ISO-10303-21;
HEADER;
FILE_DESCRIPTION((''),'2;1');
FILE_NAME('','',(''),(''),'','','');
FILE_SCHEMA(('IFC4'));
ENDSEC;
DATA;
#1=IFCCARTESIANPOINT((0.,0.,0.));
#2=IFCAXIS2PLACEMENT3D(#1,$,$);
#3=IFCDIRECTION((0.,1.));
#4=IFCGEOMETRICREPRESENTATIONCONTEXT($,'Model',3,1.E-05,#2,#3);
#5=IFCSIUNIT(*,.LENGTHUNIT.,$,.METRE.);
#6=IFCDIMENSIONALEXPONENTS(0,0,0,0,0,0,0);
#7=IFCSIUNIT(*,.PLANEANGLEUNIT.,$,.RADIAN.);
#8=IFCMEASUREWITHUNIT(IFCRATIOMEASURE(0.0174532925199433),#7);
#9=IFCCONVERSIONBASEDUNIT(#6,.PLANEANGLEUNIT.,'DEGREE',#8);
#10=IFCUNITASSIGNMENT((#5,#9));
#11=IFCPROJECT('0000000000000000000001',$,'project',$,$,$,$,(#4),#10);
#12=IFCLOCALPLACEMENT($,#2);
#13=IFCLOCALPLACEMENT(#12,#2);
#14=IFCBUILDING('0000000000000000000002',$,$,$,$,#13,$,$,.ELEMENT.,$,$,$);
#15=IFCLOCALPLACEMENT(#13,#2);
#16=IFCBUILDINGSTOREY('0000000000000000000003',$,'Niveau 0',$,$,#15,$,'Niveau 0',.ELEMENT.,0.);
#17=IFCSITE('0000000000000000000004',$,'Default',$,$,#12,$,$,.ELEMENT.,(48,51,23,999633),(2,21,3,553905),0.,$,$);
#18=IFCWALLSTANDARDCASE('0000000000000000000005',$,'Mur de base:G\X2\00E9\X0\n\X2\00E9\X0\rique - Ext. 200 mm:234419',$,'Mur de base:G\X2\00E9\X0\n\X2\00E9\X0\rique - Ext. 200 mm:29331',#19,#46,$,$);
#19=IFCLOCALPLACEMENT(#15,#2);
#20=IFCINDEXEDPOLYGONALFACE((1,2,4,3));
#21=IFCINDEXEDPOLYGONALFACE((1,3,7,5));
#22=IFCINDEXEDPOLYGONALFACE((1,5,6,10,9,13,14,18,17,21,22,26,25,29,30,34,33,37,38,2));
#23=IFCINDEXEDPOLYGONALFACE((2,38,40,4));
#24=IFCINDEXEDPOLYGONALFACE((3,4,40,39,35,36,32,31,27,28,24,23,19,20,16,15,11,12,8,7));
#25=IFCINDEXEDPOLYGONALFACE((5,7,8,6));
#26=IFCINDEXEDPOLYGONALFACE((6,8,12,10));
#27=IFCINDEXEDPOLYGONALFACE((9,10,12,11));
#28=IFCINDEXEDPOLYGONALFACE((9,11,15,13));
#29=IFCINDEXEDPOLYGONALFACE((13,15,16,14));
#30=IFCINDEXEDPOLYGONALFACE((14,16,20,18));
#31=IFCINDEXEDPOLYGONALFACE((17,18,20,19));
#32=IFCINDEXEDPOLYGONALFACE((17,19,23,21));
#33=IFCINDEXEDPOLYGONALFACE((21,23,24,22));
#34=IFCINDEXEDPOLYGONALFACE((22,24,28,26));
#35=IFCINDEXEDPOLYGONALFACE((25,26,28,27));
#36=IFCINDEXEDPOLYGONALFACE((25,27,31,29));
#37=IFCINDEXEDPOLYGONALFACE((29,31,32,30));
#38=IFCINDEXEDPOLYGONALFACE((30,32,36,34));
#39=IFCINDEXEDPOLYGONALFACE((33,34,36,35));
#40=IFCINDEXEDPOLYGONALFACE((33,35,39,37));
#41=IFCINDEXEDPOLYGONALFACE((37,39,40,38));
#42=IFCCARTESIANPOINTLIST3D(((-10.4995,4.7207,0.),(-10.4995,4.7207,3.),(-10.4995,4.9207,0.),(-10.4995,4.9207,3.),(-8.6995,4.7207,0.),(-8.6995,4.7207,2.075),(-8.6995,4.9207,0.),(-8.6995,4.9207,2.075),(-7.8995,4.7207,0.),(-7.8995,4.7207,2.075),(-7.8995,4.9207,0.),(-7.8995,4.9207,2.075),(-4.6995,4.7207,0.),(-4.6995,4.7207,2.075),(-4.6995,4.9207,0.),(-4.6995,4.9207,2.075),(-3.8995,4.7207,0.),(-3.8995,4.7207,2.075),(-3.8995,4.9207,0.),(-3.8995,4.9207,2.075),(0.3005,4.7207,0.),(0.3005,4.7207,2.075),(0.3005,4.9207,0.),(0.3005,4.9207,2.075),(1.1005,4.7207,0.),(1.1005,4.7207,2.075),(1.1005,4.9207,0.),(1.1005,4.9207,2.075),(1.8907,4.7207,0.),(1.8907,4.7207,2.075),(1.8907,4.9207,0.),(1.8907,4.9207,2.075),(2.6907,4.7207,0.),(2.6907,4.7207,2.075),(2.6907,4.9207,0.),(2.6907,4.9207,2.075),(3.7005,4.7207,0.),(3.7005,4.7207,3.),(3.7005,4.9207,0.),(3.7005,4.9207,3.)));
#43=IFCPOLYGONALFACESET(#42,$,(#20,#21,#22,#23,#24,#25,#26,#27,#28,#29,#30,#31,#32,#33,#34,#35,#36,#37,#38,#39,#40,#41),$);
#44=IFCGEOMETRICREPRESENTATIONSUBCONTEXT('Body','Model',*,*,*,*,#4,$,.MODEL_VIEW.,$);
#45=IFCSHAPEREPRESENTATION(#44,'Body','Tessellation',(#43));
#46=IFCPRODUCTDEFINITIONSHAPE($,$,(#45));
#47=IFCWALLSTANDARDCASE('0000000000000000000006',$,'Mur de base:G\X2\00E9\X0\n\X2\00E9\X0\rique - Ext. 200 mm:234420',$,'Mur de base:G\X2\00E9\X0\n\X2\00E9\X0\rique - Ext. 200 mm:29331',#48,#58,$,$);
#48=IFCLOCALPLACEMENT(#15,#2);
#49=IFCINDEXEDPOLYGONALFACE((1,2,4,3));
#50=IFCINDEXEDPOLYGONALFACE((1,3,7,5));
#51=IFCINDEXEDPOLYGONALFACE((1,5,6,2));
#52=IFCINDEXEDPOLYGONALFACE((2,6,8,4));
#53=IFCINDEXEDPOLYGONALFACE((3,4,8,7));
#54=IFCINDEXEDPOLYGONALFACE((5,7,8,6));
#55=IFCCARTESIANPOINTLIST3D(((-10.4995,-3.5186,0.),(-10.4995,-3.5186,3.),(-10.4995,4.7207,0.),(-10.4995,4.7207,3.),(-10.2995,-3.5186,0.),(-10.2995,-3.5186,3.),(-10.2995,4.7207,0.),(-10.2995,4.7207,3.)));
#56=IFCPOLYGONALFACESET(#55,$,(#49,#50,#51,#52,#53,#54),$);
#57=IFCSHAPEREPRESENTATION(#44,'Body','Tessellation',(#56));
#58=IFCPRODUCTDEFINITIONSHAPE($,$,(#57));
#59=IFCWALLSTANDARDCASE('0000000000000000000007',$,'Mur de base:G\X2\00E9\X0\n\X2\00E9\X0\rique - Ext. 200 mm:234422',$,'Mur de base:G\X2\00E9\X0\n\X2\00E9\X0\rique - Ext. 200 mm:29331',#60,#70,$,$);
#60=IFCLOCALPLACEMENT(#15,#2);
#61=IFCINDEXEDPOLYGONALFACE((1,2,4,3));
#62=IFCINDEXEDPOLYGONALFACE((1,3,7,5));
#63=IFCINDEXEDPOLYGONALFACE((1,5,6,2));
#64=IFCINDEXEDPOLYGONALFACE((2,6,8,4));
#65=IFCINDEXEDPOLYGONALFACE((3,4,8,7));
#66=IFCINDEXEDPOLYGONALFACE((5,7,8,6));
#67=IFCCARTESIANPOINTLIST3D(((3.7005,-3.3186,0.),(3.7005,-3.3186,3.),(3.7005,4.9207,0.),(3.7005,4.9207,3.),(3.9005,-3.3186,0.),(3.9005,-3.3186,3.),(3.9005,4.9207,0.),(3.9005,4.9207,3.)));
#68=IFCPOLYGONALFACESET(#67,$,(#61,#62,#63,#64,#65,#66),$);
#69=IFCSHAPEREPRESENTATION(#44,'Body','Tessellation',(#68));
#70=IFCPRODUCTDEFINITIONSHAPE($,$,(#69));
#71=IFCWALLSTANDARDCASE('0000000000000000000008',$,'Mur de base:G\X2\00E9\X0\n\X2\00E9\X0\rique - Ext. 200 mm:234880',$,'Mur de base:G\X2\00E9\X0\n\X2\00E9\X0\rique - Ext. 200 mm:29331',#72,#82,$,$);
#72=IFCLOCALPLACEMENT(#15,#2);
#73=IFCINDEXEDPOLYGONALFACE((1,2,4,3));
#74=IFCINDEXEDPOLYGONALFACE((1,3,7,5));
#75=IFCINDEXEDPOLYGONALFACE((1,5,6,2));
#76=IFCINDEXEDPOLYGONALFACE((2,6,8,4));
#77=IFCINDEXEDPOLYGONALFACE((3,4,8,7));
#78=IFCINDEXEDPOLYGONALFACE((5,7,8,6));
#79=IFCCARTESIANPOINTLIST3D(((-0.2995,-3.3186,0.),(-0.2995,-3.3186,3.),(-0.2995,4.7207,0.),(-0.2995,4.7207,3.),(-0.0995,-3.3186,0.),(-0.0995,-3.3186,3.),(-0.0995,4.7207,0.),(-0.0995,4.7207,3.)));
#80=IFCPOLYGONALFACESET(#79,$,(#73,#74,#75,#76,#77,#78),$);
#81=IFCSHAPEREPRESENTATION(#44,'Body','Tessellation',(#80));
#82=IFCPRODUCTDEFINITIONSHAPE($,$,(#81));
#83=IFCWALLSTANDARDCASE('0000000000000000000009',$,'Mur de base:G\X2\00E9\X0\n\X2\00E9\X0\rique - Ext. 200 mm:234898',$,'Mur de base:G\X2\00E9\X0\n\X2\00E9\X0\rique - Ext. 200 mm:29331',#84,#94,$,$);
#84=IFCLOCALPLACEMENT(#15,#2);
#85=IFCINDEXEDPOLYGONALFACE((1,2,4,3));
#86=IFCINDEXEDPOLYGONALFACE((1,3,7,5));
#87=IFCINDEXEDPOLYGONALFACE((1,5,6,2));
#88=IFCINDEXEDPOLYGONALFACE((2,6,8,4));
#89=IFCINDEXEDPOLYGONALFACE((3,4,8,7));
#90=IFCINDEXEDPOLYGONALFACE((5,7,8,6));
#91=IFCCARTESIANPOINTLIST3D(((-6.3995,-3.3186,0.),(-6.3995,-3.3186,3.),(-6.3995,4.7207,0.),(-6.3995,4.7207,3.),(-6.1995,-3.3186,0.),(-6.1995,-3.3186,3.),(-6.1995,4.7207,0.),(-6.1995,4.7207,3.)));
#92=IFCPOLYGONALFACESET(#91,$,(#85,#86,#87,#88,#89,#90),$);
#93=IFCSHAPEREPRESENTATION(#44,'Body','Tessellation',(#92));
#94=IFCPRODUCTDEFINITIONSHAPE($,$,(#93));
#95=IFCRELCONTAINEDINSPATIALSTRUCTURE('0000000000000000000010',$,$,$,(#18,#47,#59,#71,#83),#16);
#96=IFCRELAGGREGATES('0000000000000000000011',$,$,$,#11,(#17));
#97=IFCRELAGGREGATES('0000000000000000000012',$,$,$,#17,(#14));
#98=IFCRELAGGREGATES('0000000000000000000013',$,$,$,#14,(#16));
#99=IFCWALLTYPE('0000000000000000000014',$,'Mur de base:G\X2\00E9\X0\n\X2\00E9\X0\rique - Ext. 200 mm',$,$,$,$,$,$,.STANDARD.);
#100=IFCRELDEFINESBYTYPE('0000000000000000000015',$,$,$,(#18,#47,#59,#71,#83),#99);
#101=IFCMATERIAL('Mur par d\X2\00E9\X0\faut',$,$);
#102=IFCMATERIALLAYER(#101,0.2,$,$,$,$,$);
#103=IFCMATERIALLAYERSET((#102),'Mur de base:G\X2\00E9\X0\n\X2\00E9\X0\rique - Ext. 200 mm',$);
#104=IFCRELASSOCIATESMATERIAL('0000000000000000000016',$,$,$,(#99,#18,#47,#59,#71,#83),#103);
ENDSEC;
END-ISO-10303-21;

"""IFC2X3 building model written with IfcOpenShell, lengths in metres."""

from ifc_helpers import new_model, entity, si_unit, converted_unit, direction, frame, frame_2d, origin, place, context, subcontext, project, spatial, rectangle, extrude, material, layer, layer_set, layer_usage, type_object, element, save


model = new_model("IFC2X3")

# Units and contexts
model_context = context("Model", 3, precision=1e-05, world=origin(), true_north=direction((0.0, 1.0)))
body_context = subcontext(model_context, "Body", "Model", "MODEL_VIEW")
ifc_project = project(units=[si_unit("LENGTHUNIT", "METRE"), converted_unit("PLANEANGLEUNIT", "DEGREE", entity("IfcRatioMeasure", 0.0174532925199433), si_unit("PLANEANGLEUNIT", "RADIAN"), dimensions=[0, 0, 0, 0, 0, 0, 0])], contexts=[model_context])

# Site, building, storey
site_placement = place(None, origin())
site = spatial("IfcSite", under=ifc_project, at=site_placement, Name="Default", CompositionType="ELEMENT", RefLatitude=(48, 51, 23, 999633), RefLongitude=(2, 21, 3, 553905), RefElevation=0.0)
building_placement = place(site_placement, origin())
building = spatial("IfcBuilding", under=site, at=building_placement, CompositionType="ELEMENT")
storey_placement = place(building_placement, origin())
storey = spatial("IfcBuildingStorey", under=building, at=storey_placement, Name="Niveau 0", LongName="Niveau 0", CompositionType="ELEMENT", Elevation=0.0)

# Wall, openings
ifc_material = material(Name="Mur par défaut")
ifc_layer = layer(ifc_material, 0.2)
ifc_layer_set = layer_set([ifc_layer], Name="Mur de base:Générique - Ext. 200 mm")
ifc_layer_usage_1 = layer_usage(ifc_layer_set, "AXIS2", "NEGATIVE", 0.1)
wall_type = type_object("IfcWallType", Name="Mur de base:Générique - Ext. 200 mm", PredefinedType="STANDARD", material=ifc_layer_set)
wall_1_placement = place(storey_placement, frame((-10.4995, 4.8207, 0.0)))
wall_1 = element("IfcWallStandardCase", 1, at=wall_1_placement, inside=storey, type_object=wall_type, material=ifc_layer_usage_1, Name="Mur de base:Générique - Ext. 200 mm:234419", ObjectType="Mur de base:Générique - Ext. 200 mm:29331", context=body_context, shape_type="SweptSolid", body=[
    extrude(rectangle(XDim=14.2, YDim=0.2, at=frame_2d((7.1, 0.0), x_axis=(-1.0, 0.0))), origin(), (0.0, 0.0, 1.0), 3.0),
])
opening_1_placement = place(wall_1_placement, frame((2.6, 0.1, 0.0)))
element("IfcOpeningElement", 2, at=opening_1_placement, cuts=wall_1, ObjectType="Opening", context=body_context, shape_type="SweptSolid", body=[
    extrude(rectangle(XDim=2.075, YDim=0.8, at=frame_2d((1.0375, 0.4), x_axis=(1.0, 0.0))), frame((0.0, 0.0, 0.0), z_axis=(0.0, -1.0, 0.0), x_axis=(0.0, 0.0, 1.0)), (0.0, 0.0, 1.0), 0.2),
])
opening_2_placement = place(wall_1_placement, frame((6.6, 0.1, 0.0)))
element("IfcOpeningElement", 3, at=opening_2_placement, cuts=wall_1, ObjectType="Opening", context=body_context, shape_type="SweptSolid", body=[
    extrude(rectangle(XDim=2.075, YDim=0.8, at=frame_2d((1.0375, 0.4), x_axis=(1.0, 0.0))), frame((0.0, 0.0, 0.0), z_axis=(0.0, -1.0, 0.0), x_axis=(0.0, 0.0, 1.0)), (0.0, 0.0, 1.0), 0.2),
])
opening_3_placement = place(wall_1_placement, frame((10.8, -0.1, 0.0)))
element("IfcOpeningElement", 4, at=opening_3_placement, cuts=wall_1, ObjectType="Opening", context=body_context, shape_type="SweptSolid", body=[
    extrude(rectangle(XDim=2.075, YDim=0.8, at=frame_2d((1.0375, 0.4), x_axis=(1.0, 0.0))), frame((0.0, 0.0, 0.0), z_axis=(0.0, 1.0, 0.0), x_axis=(0.0, 0.0, 1.0)), (0.0, 0.0, 1.0), 0.2),
])
opening_4_placement = place(wall_1_placement, frame((12.3903, -0.1, 0.0)))
element("IfcOpeningElement", 5, at=opening_4_placement, cuts=wall_1, ObjectType="Opening", context=body_context, shape_type="SweptSolid", body=[
    extrude(rectangle(XDim=2.075, YDim=0.8, at=frame_2d((1.0375, 0.4), x_axis=(1.0, 0.0))), frame((0.0, 0.0, 0.0), z_axis=(0.0, 1.0, 0.0), x_axis=(0.0, 0.0, 1.0)), (0.0, 0.0, 1.0), 0.2),
])

# Walls
ifc_layer_usage_2 = layer_usage(ifc_layer_set, "AXIS2", "NEGATIVE", 0.1)
wall_2_placement = place(storey_placement, frame((-10.3995, -3.5186, 0.0), z_axis=(0.0, 0.0, 1.0), x_axis=(0.0, 1.0, 0.0)))
element("IfcWallStandardCase", 6, at=wall_2_placement, inside=storey, type_object=wall_type, material=ifc_layer_usage_2, Name="Mur de base:Générique - Ext. 200 mm:234420", ObjectType="Mur de base:Générique - Ext. 200 mm:29331", context=body_context, shape_type="SweptSolid", body=[
    extrude(rectangle(XDim=8.2393, YDim=0.2, at=frame_2d((4.1196, 0.0), x_axis=(-1.0, 0.0))), origin(), (0.0, 0.0, 1.0), 3.0),
])
ifc_layer_usage_3 = layer_usage(ifc_layer_set, "AXIS2", "NEGATIVE", 0.1)
wall_3_placement = place(storey_placement, frame((3.8005, 4.9207, 0.0), z_axis=(0.0, 0.0, 1.0), x_axis=(0.0, -1.0, 0.0)))
element("IfcWallStandardCase", 7, at=wall_3_placement, inside=storey, type_object=wall_type, material=ifc_layer_usage_3, Name="Mur de base:Générique - Ext. 200 mm:234422", ObjectType="Mur de base:Générique - Ext. 200 mm:29331", context=body_context, shape_type="SweptSolid", body=[
    extrude(rectangle(XDim=8.2393, YDim=0.2, at=frame_2d((4.1196, 0.0), x_axis=(-1.0, 0.0))), origin(), (0.0, 0.0, 1.0), 3.0),
])
ifc_layer_usage_4 = layer_usage(ifc_layer_set, "AXIS2", "NEGATIVE", 0.1)
wall_4_placement = place(storey_placement, frame((-0.1995, 4.7207, 0.0), z_axis=(0.0, 0.0, 1.0), x_axis=(0.0, -1.0, 0.0)))
element("IfcWallStandardCase", 8, at=wall_4_placement, inside=storey, type_object=wall_type, material=ifc_layer_usage_4, Name="Mur de base:Générique - Ext. 200 mm:234880", ObjectType="Mur de base:Générique - Ext. 200 mm:29331", context=body_context, shape_type="SweptSolid", body=[
    extrude(rectangle(XDim=8.0393, YDim=0.2, at=frame_2d((4.0196, 0.0), x_axis=(-1.0, 0.0))), origin(), (0.0, 0.0, 1.0), 3.0),
])
ifc_layer_usage_5 = layer_usage(ifc_layer_set, "AXIS2", "NEGATIVE", 0.1)
wall_5_placement = place(storey_placement, frame((-6.2995, 4.7207, 0.0), z_axis=(0.0, 0.0, 1.0), x_axis=(0.0, -1.0, 0.0)))
element("IfcWallStandardCase", 9, at=wall_5_placement, inside=storey, type_object=wall_type, material=ifc_layer_usage_5, Name="Mur de base:Générique - Ext. 200 mm:234898", ObjectType="Mur de base:Générique - Ext. 200 mm:29331", context=body_context, shape_type="SweptSolid", body=[
    extrude(rectangle(XDim=8.0393, YDim=0.2, at=frame_2d((4.0196, 0.0), x_axis=(-1.0, 0.0))), origin(), (0.0, 0.0, 1.0), 3.0),
])

save(model, "model.ifc")
